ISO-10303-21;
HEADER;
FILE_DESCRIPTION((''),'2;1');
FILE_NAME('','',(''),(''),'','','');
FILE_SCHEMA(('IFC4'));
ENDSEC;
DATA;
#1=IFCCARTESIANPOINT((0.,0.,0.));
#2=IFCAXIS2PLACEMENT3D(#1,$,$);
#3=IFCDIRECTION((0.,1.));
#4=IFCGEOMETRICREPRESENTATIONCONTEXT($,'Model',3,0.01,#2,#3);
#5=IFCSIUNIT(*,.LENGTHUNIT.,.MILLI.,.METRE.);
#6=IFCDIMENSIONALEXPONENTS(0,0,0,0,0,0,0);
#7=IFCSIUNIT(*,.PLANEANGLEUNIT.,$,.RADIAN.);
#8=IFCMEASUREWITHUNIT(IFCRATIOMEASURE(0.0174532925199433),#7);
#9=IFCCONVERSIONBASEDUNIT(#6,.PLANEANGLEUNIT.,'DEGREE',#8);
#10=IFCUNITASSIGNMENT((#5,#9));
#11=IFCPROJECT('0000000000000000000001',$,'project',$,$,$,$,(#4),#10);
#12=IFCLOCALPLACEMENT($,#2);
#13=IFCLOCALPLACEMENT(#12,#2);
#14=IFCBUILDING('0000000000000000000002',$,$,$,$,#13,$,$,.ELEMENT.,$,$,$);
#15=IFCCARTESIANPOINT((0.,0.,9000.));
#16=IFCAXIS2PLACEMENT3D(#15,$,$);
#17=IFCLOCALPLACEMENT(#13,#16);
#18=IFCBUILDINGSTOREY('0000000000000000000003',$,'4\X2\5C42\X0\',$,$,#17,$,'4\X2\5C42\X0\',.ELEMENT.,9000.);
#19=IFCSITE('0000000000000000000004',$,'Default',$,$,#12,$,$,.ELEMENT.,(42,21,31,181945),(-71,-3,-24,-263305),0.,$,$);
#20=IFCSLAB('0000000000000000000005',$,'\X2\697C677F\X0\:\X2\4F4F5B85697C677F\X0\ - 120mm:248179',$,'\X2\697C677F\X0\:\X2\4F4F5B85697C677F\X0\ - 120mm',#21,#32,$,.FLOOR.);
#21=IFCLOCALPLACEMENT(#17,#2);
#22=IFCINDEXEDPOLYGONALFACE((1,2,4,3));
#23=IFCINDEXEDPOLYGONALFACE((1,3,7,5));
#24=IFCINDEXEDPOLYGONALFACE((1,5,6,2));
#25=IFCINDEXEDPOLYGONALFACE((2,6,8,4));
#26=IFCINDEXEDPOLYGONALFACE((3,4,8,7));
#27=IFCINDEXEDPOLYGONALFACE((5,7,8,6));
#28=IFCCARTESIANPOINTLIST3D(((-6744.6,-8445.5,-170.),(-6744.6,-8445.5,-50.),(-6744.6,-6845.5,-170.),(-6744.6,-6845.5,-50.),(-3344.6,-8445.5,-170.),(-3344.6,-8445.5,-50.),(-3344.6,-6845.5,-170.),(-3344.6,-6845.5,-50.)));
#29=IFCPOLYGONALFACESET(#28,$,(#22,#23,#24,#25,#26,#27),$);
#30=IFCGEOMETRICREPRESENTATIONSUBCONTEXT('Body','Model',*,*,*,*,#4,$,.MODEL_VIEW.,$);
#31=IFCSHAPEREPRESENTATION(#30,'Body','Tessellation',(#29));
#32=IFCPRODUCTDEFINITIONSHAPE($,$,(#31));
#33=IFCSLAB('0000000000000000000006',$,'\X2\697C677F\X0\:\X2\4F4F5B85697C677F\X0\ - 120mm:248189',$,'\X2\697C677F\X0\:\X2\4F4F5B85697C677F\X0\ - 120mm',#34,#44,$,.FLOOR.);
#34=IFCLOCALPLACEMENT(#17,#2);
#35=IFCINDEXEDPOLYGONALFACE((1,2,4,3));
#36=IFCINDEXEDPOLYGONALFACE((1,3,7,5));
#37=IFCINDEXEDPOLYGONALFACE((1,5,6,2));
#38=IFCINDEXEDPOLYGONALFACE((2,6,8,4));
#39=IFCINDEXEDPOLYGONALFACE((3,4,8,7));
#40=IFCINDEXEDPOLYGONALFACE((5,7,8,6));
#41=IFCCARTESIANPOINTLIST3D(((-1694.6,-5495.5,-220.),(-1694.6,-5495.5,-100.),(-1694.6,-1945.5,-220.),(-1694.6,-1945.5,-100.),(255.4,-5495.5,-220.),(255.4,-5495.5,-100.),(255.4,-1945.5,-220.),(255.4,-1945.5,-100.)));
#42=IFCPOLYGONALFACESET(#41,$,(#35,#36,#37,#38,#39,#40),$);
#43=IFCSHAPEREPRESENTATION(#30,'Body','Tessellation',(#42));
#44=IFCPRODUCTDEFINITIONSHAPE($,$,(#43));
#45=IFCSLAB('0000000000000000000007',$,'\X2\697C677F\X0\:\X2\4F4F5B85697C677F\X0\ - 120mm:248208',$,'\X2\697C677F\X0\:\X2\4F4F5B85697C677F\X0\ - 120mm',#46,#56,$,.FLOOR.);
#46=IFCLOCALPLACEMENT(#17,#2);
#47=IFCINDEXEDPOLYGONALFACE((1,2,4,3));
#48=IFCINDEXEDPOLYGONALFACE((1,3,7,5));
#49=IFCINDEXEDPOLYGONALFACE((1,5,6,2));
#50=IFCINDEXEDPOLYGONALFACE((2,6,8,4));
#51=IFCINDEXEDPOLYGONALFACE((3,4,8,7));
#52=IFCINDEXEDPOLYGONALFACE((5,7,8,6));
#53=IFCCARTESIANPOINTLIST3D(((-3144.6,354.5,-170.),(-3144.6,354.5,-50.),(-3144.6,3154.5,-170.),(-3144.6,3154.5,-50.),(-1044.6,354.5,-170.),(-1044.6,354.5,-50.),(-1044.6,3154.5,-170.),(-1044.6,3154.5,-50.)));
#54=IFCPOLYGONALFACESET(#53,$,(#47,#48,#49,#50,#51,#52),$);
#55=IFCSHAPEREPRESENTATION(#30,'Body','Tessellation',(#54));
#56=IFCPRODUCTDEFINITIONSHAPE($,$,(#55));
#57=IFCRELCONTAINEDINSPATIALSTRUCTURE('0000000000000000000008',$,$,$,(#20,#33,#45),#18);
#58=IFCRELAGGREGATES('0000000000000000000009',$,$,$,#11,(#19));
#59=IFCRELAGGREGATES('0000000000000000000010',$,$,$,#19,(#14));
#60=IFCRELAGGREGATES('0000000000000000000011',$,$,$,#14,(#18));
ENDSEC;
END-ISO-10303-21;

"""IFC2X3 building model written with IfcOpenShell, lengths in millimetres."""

from ifc_helpers import new_model, entity, si_unit, converted_unit, direction, frame, frame_2d, origin, origin_2d_with_axis, place, context, subcontext, project, spatial, rectangle, extrude, element, save


model = new_model("IFC2X3")

# Units and contexts
model_context = context("Model", 3, precision=0.01, world=origin(), true_north=direction((0.0, 1.0)))
body_context = subcontext(model_context, "Body", "Model", "MODEL_VIEW")
ifc_project = project(units=[si_unit("LENGTHUNIT", "METRE", prefix="MILLI"), converted_unit("PLANEANGLEUNIT", "DEGREE", entity("IfcRatioMeasure", 0.0174532925199433), si_unit("PLANEANGLEUNIT", "RADIAN"), dimensions=[0, 0, 0, 0, 0, 0, 0])], contexts=[model_context])

# Site, building, storey
site_placement = place(None, origin())
site = spatial("IfcSite", under=ifc_project, at=site_placement, Name="Default", CompositionType="ELEMENT", RefLatitude=(42, 21, 31, 181945), RefLongitude=(-71, -3, -24, -263305), RefElevation=0.0)
building_placement = place(site_placement, origin())
building = spatial("IfcBuilding", under=site, at=building_placement, CompositionType="ELEMENT")
storey_placement = place(building_placement, frame((0.0, 0.0, 9000.0)))
storey = spatial("IfcBuildingStorey", under=building, at=storey_placement, Name="4层", LongName="4层", CompositionType="ELEMENT", Elevation=9000.0)

# Slabs
slab_1_placement = place(storey_placement, origin())
element("IfcSlab", 1, at=slab_1_placement, inside=storey, Name="楼板:住宅楼板 - 120mm:248179", ObjectType="楼板:住宅楼板 - 120mm", PredefinedType="FLOOR", context=body_context, shape_type="SweptSolid", body=[
    extrude(rectangle(XDim=1600.0, YDim=3400.0, at=frame_2d((0.0, 0.0), x_axis=(1.0, 0.0))), frame((-5044.6, -7645.5, -50.0), z_axis=(0.0, 0.0, -1.0), x_axis=(0.0, 1.0, 0.0)), (0.0, 0.0, 1.0), 120.0),
])
slab_2_placement = place(storey_placement, frame((-1694.6, -5495.5, -220.0)))
element("IfcSlab", 2, at=slab_2_placement, inside=storey, Name="楼板:住宅楼板 - 120mm:248189", ObjectType="楼板:住宅楼板 - 120mm", PredefinedType="FLOOR", context=body_context, shape_type="SweptSolid", body=[
    extrude(rectangle(XDim=3550.0, YDim=1950.0, at=frame_2d((1075.0, 0.0), x_axis=(0.0, -1.0))), frame((2050.0, 1775.0, 120.0), z_axis=(0.0, 0.0, -1.0), x_axis=(-1.0, 0.0, 0.0)), (0.0, 0.0, 1.0), 120.0),
])
slab_3_placement = place(storey_placement, origin())
element("IfcSlab", 3, at=slab_3_placement, inside=storey, Name="楼板:住宅楼板 - 120mm:248208", ObjectType="楼板:住宅楼板 - 120mm", PredefinedType="FLOOR", context=body_context, shape_type="SweptSolid", body=[
    extrude(rectangle(XDim=2800.0, YDim=2100.0, at=origin_2d_with_axis()), frame((-2094.6, 1754.5, -50.0), z_axis=(0.0, 0.0, -1.0), x_axis=(0.0, 1.0, 0.0)), (0.0, 0.0, 1.0), 120.0),
])

save(model, "model.ifc")
